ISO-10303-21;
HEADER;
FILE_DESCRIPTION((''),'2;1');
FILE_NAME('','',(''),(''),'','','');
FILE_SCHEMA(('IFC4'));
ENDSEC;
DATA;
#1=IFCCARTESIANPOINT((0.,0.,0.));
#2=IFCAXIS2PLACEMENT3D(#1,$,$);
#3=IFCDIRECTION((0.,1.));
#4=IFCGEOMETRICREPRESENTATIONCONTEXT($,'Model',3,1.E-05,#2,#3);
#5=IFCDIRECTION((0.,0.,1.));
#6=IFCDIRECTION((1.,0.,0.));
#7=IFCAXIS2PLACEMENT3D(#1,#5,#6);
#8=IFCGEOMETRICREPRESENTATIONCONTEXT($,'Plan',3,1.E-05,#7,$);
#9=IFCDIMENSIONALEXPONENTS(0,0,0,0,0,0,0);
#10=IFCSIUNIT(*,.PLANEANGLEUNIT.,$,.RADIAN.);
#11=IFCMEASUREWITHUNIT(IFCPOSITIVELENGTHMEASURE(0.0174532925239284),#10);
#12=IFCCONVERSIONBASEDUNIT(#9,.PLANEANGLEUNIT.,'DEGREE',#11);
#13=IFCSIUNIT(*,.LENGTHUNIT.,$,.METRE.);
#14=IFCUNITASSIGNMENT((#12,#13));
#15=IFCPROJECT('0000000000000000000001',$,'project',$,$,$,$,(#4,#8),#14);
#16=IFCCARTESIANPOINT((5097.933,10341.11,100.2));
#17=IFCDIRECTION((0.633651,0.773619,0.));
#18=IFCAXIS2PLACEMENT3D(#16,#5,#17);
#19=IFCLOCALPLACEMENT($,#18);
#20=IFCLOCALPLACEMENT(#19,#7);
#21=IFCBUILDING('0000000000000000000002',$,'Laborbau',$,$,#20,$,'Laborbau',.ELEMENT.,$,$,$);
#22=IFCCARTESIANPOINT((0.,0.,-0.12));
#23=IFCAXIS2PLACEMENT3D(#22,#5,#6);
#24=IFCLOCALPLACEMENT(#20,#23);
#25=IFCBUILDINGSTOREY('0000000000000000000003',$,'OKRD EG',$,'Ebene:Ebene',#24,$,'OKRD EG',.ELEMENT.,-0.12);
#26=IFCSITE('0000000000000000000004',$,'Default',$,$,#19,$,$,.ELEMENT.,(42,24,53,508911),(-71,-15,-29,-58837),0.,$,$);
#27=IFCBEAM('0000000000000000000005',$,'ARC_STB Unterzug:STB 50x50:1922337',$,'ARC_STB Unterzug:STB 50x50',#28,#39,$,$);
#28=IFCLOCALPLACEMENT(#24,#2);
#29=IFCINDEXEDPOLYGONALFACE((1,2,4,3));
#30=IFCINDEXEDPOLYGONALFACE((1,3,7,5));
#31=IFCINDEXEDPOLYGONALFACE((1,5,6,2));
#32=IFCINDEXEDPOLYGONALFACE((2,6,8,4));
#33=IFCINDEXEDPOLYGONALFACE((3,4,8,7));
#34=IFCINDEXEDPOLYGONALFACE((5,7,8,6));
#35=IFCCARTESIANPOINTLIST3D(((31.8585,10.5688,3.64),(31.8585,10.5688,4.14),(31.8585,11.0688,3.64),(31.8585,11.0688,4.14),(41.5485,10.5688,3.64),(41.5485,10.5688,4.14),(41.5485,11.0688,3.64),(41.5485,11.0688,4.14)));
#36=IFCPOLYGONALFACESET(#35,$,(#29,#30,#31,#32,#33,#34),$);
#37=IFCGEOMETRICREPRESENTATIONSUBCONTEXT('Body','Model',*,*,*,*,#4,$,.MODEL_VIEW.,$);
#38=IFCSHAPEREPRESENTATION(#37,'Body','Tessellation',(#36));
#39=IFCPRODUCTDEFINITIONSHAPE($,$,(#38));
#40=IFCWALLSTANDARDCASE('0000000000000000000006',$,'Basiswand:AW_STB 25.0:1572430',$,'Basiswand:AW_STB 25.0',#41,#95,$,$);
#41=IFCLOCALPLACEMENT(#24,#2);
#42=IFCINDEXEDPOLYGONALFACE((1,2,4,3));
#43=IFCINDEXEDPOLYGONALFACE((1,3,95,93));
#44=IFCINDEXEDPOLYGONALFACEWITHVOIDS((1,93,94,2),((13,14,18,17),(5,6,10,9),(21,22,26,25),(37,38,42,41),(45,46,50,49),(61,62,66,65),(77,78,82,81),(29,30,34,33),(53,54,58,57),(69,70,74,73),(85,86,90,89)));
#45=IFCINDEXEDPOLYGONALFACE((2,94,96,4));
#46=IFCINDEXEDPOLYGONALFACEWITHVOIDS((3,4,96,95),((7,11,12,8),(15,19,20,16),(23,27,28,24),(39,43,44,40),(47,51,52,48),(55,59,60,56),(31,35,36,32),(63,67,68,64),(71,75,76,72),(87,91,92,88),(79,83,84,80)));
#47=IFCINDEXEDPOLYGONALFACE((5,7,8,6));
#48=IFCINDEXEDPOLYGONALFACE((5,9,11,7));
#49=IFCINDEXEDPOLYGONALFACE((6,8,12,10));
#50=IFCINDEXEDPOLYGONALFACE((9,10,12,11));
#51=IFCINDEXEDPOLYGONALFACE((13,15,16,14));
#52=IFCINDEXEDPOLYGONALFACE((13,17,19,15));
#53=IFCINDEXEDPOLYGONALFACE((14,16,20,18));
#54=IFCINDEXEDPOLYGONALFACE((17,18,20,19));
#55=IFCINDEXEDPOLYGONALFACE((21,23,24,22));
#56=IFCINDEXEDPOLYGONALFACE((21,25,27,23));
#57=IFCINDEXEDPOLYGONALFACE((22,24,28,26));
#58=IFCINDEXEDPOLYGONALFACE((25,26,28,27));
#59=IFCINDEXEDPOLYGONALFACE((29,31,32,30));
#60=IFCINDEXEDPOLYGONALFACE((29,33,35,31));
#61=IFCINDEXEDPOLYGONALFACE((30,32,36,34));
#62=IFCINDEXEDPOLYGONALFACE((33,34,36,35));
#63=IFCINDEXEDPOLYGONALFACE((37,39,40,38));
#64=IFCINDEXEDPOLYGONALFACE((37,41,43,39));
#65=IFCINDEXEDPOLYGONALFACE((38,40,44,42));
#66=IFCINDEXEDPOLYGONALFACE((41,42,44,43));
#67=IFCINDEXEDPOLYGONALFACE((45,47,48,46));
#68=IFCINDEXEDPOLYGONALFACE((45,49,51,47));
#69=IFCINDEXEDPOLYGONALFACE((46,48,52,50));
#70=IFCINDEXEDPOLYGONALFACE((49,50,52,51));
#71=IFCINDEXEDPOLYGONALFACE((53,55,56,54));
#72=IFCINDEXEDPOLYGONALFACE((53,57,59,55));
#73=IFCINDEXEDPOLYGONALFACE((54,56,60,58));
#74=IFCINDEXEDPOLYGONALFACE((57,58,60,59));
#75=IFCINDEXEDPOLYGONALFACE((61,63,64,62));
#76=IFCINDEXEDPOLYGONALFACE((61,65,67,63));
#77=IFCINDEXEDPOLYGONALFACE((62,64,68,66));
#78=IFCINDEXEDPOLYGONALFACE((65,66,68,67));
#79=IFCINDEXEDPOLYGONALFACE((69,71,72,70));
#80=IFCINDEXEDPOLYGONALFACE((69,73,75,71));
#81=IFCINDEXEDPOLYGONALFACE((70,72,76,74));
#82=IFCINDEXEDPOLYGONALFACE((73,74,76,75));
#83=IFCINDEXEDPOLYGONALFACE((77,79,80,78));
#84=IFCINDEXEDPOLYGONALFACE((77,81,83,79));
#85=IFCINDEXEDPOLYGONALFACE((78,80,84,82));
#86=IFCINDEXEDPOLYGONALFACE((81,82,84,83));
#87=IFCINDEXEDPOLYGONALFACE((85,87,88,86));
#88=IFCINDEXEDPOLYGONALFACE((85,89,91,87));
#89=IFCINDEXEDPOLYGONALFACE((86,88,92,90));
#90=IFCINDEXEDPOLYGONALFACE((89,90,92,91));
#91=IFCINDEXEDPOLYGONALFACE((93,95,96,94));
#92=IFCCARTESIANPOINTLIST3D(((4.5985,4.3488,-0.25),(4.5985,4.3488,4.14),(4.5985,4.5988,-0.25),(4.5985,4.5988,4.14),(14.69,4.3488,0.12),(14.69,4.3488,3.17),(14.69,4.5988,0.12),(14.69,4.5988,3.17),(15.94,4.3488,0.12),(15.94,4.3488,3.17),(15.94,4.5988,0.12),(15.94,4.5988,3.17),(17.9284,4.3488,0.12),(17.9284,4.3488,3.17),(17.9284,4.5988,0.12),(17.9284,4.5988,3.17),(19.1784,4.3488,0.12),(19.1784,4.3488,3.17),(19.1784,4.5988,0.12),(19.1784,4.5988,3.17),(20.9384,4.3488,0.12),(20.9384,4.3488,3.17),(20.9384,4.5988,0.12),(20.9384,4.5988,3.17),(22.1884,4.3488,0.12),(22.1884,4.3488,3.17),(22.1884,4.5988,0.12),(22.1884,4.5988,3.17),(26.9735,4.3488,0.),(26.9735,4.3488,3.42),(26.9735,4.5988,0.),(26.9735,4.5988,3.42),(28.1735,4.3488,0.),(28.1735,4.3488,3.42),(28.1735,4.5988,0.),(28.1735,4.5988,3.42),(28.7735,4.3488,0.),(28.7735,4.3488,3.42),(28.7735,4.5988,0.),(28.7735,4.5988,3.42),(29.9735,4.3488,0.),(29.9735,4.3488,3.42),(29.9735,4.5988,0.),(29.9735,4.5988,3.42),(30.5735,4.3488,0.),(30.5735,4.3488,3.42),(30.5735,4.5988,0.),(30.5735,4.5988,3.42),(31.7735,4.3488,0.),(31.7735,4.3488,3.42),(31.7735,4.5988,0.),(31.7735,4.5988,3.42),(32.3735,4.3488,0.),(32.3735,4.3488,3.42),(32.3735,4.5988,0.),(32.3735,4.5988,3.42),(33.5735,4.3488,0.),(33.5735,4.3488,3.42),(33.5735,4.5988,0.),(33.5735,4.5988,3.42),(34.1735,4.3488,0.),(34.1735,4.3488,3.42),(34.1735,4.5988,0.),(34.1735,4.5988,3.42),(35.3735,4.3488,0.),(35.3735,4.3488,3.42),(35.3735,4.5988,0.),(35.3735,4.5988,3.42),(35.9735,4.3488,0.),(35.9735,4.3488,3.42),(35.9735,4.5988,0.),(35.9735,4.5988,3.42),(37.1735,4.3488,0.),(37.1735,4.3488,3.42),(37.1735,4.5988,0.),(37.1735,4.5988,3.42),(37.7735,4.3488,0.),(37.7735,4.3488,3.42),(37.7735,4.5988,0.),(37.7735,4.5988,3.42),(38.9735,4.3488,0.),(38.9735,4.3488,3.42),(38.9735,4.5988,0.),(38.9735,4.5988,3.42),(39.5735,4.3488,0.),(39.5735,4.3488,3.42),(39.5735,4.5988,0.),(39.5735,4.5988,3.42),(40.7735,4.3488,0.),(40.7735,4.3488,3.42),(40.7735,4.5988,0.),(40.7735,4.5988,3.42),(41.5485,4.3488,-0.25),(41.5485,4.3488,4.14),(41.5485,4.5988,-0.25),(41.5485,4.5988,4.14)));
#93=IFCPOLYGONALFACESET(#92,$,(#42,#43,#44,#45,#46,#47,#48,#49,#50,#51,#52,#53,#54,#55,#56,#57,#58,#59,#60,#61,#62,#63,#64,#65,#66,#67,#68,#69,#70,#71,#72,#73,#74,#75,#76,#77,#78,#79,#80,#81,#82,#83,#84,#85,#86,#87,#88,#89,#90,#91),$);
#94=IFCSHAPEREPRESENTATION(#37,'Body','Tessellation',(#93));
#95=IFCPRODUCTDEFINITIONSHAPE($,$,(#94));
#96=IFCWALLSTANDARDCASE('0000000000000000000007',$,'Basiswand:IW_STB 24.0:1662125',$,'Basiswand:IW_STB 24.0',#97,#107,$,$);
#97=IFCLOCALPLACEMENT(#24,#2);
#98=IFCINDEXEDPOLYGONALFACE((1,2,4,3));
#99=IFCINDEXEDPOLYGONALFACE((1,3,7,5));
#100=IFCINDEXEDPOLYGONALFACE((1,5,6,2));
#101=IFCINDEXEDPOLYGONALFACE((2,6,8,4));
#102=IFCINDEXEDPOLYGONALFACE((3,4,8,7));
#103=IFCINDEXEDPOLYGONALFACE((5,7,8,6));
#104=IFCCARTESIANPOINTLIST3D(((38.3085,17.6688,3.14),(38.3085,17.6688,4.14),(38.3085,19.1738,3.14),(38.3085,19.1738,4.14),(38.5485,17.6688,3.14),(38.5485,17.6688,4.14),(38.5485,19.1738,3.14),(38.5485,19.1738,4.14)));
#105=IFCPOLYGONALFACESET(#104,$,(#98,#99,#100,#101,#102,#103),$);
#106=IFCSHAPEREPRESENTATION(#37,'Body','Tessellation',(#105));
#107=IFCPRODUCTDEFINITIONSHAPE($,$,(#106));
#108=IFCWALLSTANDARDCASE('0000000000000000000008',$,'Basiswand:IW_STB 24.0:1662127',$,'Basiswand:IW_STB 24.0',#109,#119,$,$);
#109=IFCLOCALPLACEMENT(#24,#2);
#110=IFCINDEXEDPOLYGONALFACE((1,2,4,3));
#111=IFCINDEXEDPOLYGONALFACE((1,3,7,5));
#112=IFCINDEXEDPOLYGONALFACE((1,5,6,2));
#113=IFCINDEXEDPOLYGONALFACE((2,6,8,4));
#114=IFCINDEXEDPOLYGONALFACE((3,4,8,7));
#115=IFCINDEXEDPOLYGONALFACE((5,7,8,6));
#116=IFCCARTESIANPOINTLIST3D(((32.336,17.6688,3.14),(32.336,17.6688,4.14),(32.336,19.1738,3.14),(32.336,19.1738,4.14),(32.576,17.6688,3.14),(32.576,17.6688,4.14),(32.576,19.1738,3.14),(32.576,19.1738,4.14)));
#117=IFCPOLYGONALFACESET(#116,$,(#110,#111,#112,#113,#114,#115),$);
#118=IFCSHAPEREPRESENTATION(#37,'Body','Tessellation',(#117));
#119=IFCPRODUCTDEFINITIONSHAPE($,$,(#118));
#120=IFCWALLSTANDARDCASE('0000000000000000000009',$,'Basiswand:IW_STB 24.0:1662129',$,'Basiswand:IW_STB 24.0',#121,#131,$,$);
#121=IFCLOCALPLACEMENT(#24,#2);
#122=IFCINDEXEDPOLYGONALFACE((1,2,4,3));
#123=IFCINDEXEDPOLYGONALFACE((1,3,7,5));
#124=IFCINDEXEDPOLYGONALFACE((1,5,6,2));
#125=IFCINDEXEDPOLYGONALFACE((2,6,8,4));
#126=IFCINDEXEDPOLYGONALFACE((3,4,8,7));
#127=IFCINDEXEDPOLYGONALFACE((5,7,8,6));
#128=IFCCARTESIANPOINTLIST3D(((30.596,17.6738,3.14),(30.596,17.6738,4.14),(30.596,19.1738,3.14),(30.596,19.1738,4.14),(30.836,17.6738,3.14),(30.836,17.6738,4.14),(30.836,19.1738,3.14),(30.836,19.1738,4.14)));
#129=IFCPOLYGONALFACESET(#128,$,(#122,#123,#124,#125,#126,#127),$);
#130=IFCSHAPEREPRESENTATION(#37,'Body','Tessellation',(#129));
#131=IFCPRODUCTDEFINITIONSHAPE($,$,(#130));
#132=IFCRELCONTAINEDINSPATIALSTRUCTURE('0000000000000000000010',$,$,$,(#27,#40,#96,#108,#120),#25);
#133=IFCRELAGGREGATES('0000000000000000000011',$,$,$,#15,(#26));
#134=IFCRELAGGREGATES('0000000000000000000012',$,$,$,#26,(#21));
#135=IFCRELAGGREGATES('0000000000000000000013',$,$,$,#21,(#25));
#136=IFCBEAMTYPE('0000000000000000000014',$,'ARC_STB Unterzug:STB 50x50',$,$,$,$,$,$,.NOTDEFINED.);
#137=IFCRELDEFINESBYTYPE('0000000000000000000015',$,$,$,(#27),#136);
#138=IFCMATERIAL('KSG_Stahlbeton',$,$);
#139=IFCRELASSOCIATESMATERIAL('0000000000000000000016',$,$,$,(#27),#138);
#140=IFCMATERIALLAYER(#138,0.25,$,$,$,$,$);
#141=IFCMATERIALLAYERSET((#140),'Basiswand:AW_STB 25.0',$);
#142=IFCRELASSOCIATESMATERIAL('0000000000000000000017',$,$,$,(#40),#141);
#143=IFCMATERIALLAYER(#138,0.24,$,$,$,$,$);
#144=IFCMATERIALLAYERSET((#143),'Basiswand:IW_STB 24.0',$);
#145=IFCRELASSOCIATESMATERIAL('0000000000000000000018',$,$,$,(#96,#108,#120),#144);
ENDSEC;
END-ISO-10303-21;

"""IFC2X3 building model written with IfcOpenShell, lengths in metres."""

from ifc_helpers import new_model, entity, si_unit, converted_unit, direction, frame, frame_2d, origin, origin_with_axes, origin_2d_with_axis, place, context, subcontext, project, spatial, rectangle, extrude, material, layer, layer_set, layer_usage, type_object, element, save


model = new_model("IFC2X3")

# Units and contexts
model_context = context("Model", 3, precision=1e-05, world=origin(), true_north=direction((0.0, 1.0)))
plan_context = context("Plan", 3, precision=1e-05, world=origin_with_axes())
body_context = subcontext(model_context, "Body", "Model", "MODEL_VIEW")
ifc_project = project(units=[converted_unit("PLANEANGLEUNIT", "DEGREE", entity("IfcPositiveLengthMeasure", 0.0174532925239284), si_unit("PLANEANGLEUNIT", "RADIAN"), dimensions=[0, 0, 0, 0, 0, 0, 0]), si_unit("LENGTHUNIT", "METRE")], contexts=[model_context, plan_context])

# Site, building, storey
site_placement = place(None, frame((5097.933, 10341.11, 100.2), z_axis=(0.0, 0.0, 1.0), x_axis=(0.633651, 0.773619, 0.0)))
site = spatial("IfcSite", under=ifc_project, at=site_placement, Name="Default", CompositionType="ELEMENT", RefLatitude=(42, 24, 53, 508911), RefLongitude=(-71, -15, -29, -58837), RefElevation=0.0)
building_placement = place(site_placement, origin_with_axes())
building = spatial("IfcBuilding", under=site, at=building_placement, Name="Laborbau", LongName="Laborbau", CompositionType="ELEMENT")
storey_placement = place(building_placement, frame((0.0, 0.0, -0.12), z_axis=(0.0, 0.0, 1.0), x_axis=(1.0, 0.0, 0.0)))
storey = spatial("IfcBuildingStorey", under=building, at=storey_placement, Name="OKRD EG", ObjectType="Ebene:Ebene", LongName="OKRD EG", CompositionType="ELEMENT", Elevation=-0.12)

# Beam
ifc_material_1 = material(Name="KSG_Stahlbeton")
beam_type = type_object("IfcBeamType", Name="ARC_STB Unterzug:STB 50x50", PredefinedType="NOTDEFINED")
beam_placement = place(storey_placement, frame((41.6735, 10.8188, 4.14), z_axis=(0.0, 0.0, 1.0), x_axis=(-1.0, 0.0, 0.0)))
element("IfcBeam", 1, at=beam_placement, inside=storey, type_object=beam_type, material=ifc_material_1, Name="ARC_STB Unterzug:STB 50x50:1922337", ObjectType="ARC_STB Unterzug:STB 50x50", context=body_context, shape_type="SweptSolid", body=[
    extrude(rectangle(XDim=0.5, YDim=0.5, at=frame_2d((0.0, 0.0), x_axis=(1.0, 0.0))), frame((0.125, 0.0, -0.25), z_axis=(1.0, 0.0, 0.0), x_axis=(0.0, 0.0, -1.0)), (0.0, 0.0, 1.0), 9.69),
])

# Wall, openings
ifc_layer_1 = layer(ifc_material_1, 0.25)
ifc_layer_set_1 = layer_set([ifc_layer_1], Name="Basiswand:AW_STB 25.0")
ifc_layer_usage_1 = layer_usage(ifc_layer_set_1, "AXIS2", "NEGATIVE", 0.125)
wall_1_placement = place(storey_placement, frame((41.5485, 4.4738, -0.25), z_axis=(0.0, 0.0, 1.0), x_axis=(-1.0, 0.0, 0.0)))
wall_1 = element("IfcWallStandardCase", 2, at=wall_1_placement, inside=storey, material=ifc_layer_usage_1, Name="Basiswand:AW_STB 25.0:1572430", ObjectType="Basiswand:AW_STB 25.0", context=body_context, shape_type="SweptSolid", body=[
    extrude(rectangle(XDim=36.95, YDim=0.25, at=frame_2d((18.475, 0.0), x_axis=(-1.0, 0.0))), origin(), (0.0, 0.0, 1.0), 4.39),
])
opening_1_placement = place(wall_1_placement, origin_with_axes())
element("IfcOpeningElement", 3, at=opening_1_placement, cuts=wall_1, ObjectType="Opening", context=body_context, shape_type="SweptSolid", body=[
    extrude(rectangle(XDim=3.05, YDim=1.25, at=frame_2d((0.0, 0.0), x_axis=(1.0, 0.0))), frame((26.2335, -1.399, 1.895), z_axis=(0.0, 1.0, 0.0), x_axis=(0.0, 0.0, -1.0)), (0.0, 0.0, 1.0), 3.048),
])
opening_2_placement = place(wall_1_placement, origin_with_axes())
element("IfcOpeningElement", 4, at=opening_2_placement, cuts=wall_1, ObjectType="Opening", context=body_context, shape_type="SweptSolid", body=[
    extrude(rectangle(XDim=3.05, YDim=1.25, at=frame_2d((0.0, 0.0), x_axis=(1.0, 0.0))), frame((26.2335, -1.399, 1.895), z_axis=(0.0, 1.0, 0.0), x_axis=(0.0, 0.0, -1.0)), (0.0, 0.0, 1.0), 3.048),
])
opening_3_placement = place(wall_1_placement, origin_with_axes())
element("IfcOpeningElement", 5, at=opening_3_placement, cuts=wall_1, ObjectType="Opening", context=body_context, shape_type="SweptSolid", body=[
    extrude(rectangle(XDim=3.08, YDim=1.31, at=frame_2d((0.0, 0.0), x_axis=(1.0, 0.0))), frame((26.2335, 0.445, 1.91), z_axis=(0.0, 1.0, 0.0), x_axis=(0.0, 0.0, -1.0)), (0.0, 0.0, 1.0), 0.35),
])
opening_4_placement = place(wall_1_placement, frame((41.5485, 4.4738, 0.25), z_axis=(0.0, 0.0, 1.0), x_axis=(-1.0, 0.0, 0.0)))
element("IfcOpeningElement", 6, at=opening_4_placement, cuts=wall_1, ObjectType="Opening", context=body_context, shape_type="SweptSolid", body=[
    extrude(rectangle(XDim=3.05, YDim=1.25, at=origin_2d_with_axis()), frame((21.5634, 6.1228, 1.645), z_axis=(0.0, -1.0, 0.0), x_axis=(0.0, 0.0, -1.0)), (0.0, 0.0, 1.0), 3.048),
])
opening_5_placement = place(wall_1_placement, frame((19.3601, -0.125, 0.37), z_axis=(0.0, 0.0, 1.0), x_axis=(1.0, 0.0, 0.0)))
element("IfcOpeningElement", 7, at=opening_5_placement, cuts=wall_1, ObjectType="Opening", context=body_context, shape_type="SweptSolid", body=[
    extrude(rectangle(XDim=3.05, YDim=1.25, at=frame_2d((1.525, 0.625), x_axis=(-1.0, 0.0))), frame((0.0, 0.0, 0.0), z_axis=(0.0, 1.0, 0.0), x_axis=(0.0, 0.0, 1.0)), (0.0, 0.0, 1.0), 0.25),
])
opening_6_placement = place(wall_1_placement, frame((41.5485, 4.4738, 0.25), z_axis=(0.0, 0.0, 1.0), x_axis=(-1.0, 0.0, 0.0)))
element("IfcOpeningElement", 8, at=opening_6_placement, cuts=wall_1, ObjectType="Opening", context=body_context, shape_type="SweptSolid", body=[
    extrude(rectangle(XDim=3.05, YDim=1.25, at=origin_2d_with_axis()), frame((18.5534, 6.1228, 1.645), z_axis=(0.0, -1.0, 0.0), x_axis=(0.0, 0.0, -1.0)), (0.0, 0.0, 1.0), 3.048),
])
opening_7_placement = place(wall_1_placement, frame((22.3702, -0.125, 0.37), z_axis=(0.0, 0.0, 1.0), x_axis=(1.0, 0.0, 0.0)))
element("IfcOpeningElement", 9, at=opening_7_placement, cuts=wall_1, ObjectType="Opening", context=body_context, shape_type="SweptSolid", body=[
    extrude(rectangle(XDim=3.05, YDim=1.25, at=frame_2d((1.525, 0.625), x_axis=(-1.0, 0.0))), frame((0.0, 0.0, 0.0), z_axis=(0.0, 1.0, 0.0), x_axis=(0.0, 0.0, 1.0)), (0.0, 0.0, 1.0), 0.25),
])
opening_8_placement = place(wall_1_placement, frame((41.5485, 4.4738, 0.25), z_axis=(0.0, 0.0, 1.0), x_axis=(-1.0, 0.0, 0.0)))
element("IfcOpeningElement", 10, at=opening_8_placement, cuts=wall_1, ObjectType="Opening", context=body_context, shape_type="SweptSolid", body=[
    extrude(rectangle(XDim=3.42, YDim=1.2, at=origin_2d_with_axis()), frame((40.1735, 4.5988, 1.71), z_axis=(0.0, -1.0, 0.0), x_axis=(0.0, 0.0, -1.0)), (0.0, 0.0, 1.0), 0.25),
])
opening_9_placement = place(wall_1_placement, frame((41.5485, 4.4738, 0.25), z_axis=(0.0, 0.0, 1.0), x_axis=(-1.0, 0.0, 0.0)))
element("IfcOpeningElement", 11, at=opening_9_placement, cuts=wall_1, ObjectType="Opening", context=body_context, shape_type="SweptSolid", body=[
    extrude(rectangle(XDim=3.42, YDim=1.2, at=frame_2d((0.0, 0.0), x_axis=(0.0, 1.0))), frame((27.5735, 4.5988, 1.71), z_axis=(0.0, -1.0, 0.0), x_axis=(-1.0, 0.0, 0.0)), (0.0, 0.0, 1.0), 0.25),
])
opening_10_placement = place(wall_1_placement, frame((41.5485, 4.4738, 0.25), z_axis=(0.0, 0.0, 1.0), x_axis=(-1.0, 0.0, 0.0)))
element("IfcOpeningElement", 12, at=opening_10_placement, cuts=wall_1, ObjectType="Opening", context=body_context, shape_type="SweptSolid", body=[
    extrude(rectangle(XDim=3.42, YDim=1.2, at=frame_2d((0.0, 0.0), x_axis=(1.0, 0.0))), frame((29.3735, 4.5988, 1.71), z_axis=(0.0, -1.0, 0.0), x_axis=(0.0, 0.0, -1.0)), (0.0, 0.0, 1.0), 0.25),
])
opening_11_placement = place(wall_1_placement, frame((41.5485, 4.4738, 0.25), z_axis=(0.0, 0.0, 1.0), x_axis=(-1.0, 0.0, 0.0)))
element("IfcOpeningElement", 13, at=opening_11_placement, cuts=wall_1, ObjectType="Opening", context=body_context, shape_type="SweptSolid", body=[
    extrude(rectangle(XDim=3.42, YDim=1.2, at=frame_2d((0.0, 0.0), x_axis=(0.0, 1.0))), frame((31.1735, 4.5988, 1.71), z_axis=(0.0, -1.0, 0.0), x_axis=(-1.0, 0.0, 0.0)), (0.0, 0.0, 1.0), 0.25),
])
opening_12_placement = place(wall_1_placement, frame((41.5485, 4.4738, 0.25), z_axis=(0.0, 0.0, 1.0), x_axis=(-1.0, 0.0, 0.0)))
element("IfcOpeningElement", 14, at=opening_12_placement, cuts=wall_1, ObjectType="Opening", context=body_context, shape_type="SweptSolid", body=[
    extrude(rectangle(XDim=3.42, YDim=1.2, at=frame_2d((0.0, 0.0), x_axis=(1.0, 0.0))), frame((32.9735, 4.5988, 1.71), z_axis=(0.0, -1.0, 0.0), x_axis=(0.0, 0.0, -1.0)), (0.0, 0.0, 1.0), 0.25),
])
opening_13_placement = place(wall_1_placement, frame((41.5485, 4.4738, 0.25), z_axis=(0.0, 0.0, 1.0), x_axis=(-1.0, 0.0, 0.0)))
element("IfcOpeningElement", 15, at=opening_13_placement, cuts=wall_1, ObjectType="Opening", context=body_context, shape_type="SweptSolid", body=[
    extrude(rectangle(XDim=3.42, YDim=1.2, at=frame_2d((0.0, 0.0), x_axis=(0.0, 1.0))), frame((34.7735, 4.5988, 1.71), z_axis=(0.0, -1.0, 0.0), x_axis=(-1.0, 0.0, 0.0)), (0.0, 0.0, 1.0), 0.25),
])
opening_14_placement = place(wall_1_placement, frame((41.5485, 4.4738, 0.25), z_axis=(0.0, 0.0, 1.0), x_axis=(-1.0, 0.0, 0.0)))
element("IfcOpeningElement", 16, at=opening_14_placement, cuts=wall_1, ObjectType="Opening", context=body_context, shape_type="SweptSolid", body=[
    extrude(rectangle(XDim=3.42, YDim=1.2, at=frame_2d((0.0, 0.0), x_axis=(1.0, 0.0))), frame((36.5735, 4.5988, 1.71), z_axis=(0.0, -1.0, 0.0), x_axis=(0.0, 0.0, -1.0)), (0.0, 0.0, 1.0), 0.25),
])
opening_15_placement = place(wall_1_placement, frame((41.5485, 4.4738, 0.25), z_axis=(0.0, 0.0, 1.0), x_axis=(-1.0, 0.0, 0.0)))
element("IfcOpeningElement", 17, at=opening_15_placement, cuts=wall_1, ObjectType="Opening", context=body_context, shape_type="SweptSolid", body=[
    extrude(rectangle(XDim=3.42, YDim=1.2, at=frame_2d((0.0, 0.0), x_axis=(0.0, 1.0))), frame((38.3735, 4.5988, 1.71), z_axis=(0.0, -1.0, 0.0), x_axis=(-1.0, 0.0, 0.0)), (0.0, 0.0, 1.0), 0.25),
])

# Walls
ifc_layer_2 = layer(ifc_material_1, 0.24)
ifc_layer_set_2 = layer_set([ifc_layer_2], Name="Basiswand:IW_STB 24.0")
ifc_layer_usage_2 = layer_usage(ifc_layer_set_2, "AXIS2", "NEGATIVE", 0.12)
wall_2_placement = place(storey_placement, frame((38.4285, 19.1738, 3.14), z_axis=(0.0, 0.0, 1.0), x_axis=(0.0, -1.0, 0.0)))
element("IfcWallStandardCase", 18, at=wall_2_placement, inside=storey, material=ifc_layer_usage_2, Name="Basiswand:IW_STB 24.0:1662125", ObjectType="Basiswand:IW_STB 24.0", context=body_context, shape_type="SweptSolid", body=[
    extrude(rectangle(XDim=1.505, YDim=0.24, at=frame_2d((0.7525, 0.0), x_axis=(-1.0, 0.0))), origin(), (0.0, 0.0, 1.0), 1.0),
])
ifc_layer_usage_3 = layer_usage(ifc_layer_set_2, "AXIS2", "NEGATIVE", 0.12)
wall_3_placement = place(storey_placement, frame((32.456, 17.6688, 3.14), z_axis=(0.0, 0.0, 1.0), x_axis=(0.0, 1.0, 0.0)))
element("IfcWallStandardCase", 19, at=wall_3_placement, inside=storey, material=ifc_layer_usage_3, Name="Basiswand:IW_STB 24.0:1662127", ObjectType="Basiswand:IW_STB 24.0", context=body_context, shape_type="SweptSolid", body=[
    extrude(rectangle(XDim=1.505, YDim=0.24, at=frame_2d((0.7525, 0.0), x_axis=(-1.0, 0.0))), origin(), (0.0, 0.0, 1.0), 1.0),
])
ifc_layer_usage_4 = layer_usage(ifc_layer_set_2, "AXIS2", "NEGATIVE", 0.12)
wall_4_placement = place(storey_placement, frame((30.716, 19.1738, 3.14), z_axis=(0.0, 0.0, 1.0), x_axis=(0.0, -1.0, 0.0)))
element("IfcWallStandardCase", 20, at=wall_4_placement, inside=storey, material=ifc_layer_usage_4, Name="Basiswand:IW_STB 24.0:1662129", ObjectType="Basiswand:IW_STB 24.0", context=body_context, shape_type="SweptSolid", body=[
    extrude(rectangle(XDim=1.5, YDim=0.24, at=frame_2d((0.75, 0.0), x_axis=(-1.0, 0.0))), origin(), (0.0, 0.0, 1.0), 1.0),
])

save(model, "model.ifc")
